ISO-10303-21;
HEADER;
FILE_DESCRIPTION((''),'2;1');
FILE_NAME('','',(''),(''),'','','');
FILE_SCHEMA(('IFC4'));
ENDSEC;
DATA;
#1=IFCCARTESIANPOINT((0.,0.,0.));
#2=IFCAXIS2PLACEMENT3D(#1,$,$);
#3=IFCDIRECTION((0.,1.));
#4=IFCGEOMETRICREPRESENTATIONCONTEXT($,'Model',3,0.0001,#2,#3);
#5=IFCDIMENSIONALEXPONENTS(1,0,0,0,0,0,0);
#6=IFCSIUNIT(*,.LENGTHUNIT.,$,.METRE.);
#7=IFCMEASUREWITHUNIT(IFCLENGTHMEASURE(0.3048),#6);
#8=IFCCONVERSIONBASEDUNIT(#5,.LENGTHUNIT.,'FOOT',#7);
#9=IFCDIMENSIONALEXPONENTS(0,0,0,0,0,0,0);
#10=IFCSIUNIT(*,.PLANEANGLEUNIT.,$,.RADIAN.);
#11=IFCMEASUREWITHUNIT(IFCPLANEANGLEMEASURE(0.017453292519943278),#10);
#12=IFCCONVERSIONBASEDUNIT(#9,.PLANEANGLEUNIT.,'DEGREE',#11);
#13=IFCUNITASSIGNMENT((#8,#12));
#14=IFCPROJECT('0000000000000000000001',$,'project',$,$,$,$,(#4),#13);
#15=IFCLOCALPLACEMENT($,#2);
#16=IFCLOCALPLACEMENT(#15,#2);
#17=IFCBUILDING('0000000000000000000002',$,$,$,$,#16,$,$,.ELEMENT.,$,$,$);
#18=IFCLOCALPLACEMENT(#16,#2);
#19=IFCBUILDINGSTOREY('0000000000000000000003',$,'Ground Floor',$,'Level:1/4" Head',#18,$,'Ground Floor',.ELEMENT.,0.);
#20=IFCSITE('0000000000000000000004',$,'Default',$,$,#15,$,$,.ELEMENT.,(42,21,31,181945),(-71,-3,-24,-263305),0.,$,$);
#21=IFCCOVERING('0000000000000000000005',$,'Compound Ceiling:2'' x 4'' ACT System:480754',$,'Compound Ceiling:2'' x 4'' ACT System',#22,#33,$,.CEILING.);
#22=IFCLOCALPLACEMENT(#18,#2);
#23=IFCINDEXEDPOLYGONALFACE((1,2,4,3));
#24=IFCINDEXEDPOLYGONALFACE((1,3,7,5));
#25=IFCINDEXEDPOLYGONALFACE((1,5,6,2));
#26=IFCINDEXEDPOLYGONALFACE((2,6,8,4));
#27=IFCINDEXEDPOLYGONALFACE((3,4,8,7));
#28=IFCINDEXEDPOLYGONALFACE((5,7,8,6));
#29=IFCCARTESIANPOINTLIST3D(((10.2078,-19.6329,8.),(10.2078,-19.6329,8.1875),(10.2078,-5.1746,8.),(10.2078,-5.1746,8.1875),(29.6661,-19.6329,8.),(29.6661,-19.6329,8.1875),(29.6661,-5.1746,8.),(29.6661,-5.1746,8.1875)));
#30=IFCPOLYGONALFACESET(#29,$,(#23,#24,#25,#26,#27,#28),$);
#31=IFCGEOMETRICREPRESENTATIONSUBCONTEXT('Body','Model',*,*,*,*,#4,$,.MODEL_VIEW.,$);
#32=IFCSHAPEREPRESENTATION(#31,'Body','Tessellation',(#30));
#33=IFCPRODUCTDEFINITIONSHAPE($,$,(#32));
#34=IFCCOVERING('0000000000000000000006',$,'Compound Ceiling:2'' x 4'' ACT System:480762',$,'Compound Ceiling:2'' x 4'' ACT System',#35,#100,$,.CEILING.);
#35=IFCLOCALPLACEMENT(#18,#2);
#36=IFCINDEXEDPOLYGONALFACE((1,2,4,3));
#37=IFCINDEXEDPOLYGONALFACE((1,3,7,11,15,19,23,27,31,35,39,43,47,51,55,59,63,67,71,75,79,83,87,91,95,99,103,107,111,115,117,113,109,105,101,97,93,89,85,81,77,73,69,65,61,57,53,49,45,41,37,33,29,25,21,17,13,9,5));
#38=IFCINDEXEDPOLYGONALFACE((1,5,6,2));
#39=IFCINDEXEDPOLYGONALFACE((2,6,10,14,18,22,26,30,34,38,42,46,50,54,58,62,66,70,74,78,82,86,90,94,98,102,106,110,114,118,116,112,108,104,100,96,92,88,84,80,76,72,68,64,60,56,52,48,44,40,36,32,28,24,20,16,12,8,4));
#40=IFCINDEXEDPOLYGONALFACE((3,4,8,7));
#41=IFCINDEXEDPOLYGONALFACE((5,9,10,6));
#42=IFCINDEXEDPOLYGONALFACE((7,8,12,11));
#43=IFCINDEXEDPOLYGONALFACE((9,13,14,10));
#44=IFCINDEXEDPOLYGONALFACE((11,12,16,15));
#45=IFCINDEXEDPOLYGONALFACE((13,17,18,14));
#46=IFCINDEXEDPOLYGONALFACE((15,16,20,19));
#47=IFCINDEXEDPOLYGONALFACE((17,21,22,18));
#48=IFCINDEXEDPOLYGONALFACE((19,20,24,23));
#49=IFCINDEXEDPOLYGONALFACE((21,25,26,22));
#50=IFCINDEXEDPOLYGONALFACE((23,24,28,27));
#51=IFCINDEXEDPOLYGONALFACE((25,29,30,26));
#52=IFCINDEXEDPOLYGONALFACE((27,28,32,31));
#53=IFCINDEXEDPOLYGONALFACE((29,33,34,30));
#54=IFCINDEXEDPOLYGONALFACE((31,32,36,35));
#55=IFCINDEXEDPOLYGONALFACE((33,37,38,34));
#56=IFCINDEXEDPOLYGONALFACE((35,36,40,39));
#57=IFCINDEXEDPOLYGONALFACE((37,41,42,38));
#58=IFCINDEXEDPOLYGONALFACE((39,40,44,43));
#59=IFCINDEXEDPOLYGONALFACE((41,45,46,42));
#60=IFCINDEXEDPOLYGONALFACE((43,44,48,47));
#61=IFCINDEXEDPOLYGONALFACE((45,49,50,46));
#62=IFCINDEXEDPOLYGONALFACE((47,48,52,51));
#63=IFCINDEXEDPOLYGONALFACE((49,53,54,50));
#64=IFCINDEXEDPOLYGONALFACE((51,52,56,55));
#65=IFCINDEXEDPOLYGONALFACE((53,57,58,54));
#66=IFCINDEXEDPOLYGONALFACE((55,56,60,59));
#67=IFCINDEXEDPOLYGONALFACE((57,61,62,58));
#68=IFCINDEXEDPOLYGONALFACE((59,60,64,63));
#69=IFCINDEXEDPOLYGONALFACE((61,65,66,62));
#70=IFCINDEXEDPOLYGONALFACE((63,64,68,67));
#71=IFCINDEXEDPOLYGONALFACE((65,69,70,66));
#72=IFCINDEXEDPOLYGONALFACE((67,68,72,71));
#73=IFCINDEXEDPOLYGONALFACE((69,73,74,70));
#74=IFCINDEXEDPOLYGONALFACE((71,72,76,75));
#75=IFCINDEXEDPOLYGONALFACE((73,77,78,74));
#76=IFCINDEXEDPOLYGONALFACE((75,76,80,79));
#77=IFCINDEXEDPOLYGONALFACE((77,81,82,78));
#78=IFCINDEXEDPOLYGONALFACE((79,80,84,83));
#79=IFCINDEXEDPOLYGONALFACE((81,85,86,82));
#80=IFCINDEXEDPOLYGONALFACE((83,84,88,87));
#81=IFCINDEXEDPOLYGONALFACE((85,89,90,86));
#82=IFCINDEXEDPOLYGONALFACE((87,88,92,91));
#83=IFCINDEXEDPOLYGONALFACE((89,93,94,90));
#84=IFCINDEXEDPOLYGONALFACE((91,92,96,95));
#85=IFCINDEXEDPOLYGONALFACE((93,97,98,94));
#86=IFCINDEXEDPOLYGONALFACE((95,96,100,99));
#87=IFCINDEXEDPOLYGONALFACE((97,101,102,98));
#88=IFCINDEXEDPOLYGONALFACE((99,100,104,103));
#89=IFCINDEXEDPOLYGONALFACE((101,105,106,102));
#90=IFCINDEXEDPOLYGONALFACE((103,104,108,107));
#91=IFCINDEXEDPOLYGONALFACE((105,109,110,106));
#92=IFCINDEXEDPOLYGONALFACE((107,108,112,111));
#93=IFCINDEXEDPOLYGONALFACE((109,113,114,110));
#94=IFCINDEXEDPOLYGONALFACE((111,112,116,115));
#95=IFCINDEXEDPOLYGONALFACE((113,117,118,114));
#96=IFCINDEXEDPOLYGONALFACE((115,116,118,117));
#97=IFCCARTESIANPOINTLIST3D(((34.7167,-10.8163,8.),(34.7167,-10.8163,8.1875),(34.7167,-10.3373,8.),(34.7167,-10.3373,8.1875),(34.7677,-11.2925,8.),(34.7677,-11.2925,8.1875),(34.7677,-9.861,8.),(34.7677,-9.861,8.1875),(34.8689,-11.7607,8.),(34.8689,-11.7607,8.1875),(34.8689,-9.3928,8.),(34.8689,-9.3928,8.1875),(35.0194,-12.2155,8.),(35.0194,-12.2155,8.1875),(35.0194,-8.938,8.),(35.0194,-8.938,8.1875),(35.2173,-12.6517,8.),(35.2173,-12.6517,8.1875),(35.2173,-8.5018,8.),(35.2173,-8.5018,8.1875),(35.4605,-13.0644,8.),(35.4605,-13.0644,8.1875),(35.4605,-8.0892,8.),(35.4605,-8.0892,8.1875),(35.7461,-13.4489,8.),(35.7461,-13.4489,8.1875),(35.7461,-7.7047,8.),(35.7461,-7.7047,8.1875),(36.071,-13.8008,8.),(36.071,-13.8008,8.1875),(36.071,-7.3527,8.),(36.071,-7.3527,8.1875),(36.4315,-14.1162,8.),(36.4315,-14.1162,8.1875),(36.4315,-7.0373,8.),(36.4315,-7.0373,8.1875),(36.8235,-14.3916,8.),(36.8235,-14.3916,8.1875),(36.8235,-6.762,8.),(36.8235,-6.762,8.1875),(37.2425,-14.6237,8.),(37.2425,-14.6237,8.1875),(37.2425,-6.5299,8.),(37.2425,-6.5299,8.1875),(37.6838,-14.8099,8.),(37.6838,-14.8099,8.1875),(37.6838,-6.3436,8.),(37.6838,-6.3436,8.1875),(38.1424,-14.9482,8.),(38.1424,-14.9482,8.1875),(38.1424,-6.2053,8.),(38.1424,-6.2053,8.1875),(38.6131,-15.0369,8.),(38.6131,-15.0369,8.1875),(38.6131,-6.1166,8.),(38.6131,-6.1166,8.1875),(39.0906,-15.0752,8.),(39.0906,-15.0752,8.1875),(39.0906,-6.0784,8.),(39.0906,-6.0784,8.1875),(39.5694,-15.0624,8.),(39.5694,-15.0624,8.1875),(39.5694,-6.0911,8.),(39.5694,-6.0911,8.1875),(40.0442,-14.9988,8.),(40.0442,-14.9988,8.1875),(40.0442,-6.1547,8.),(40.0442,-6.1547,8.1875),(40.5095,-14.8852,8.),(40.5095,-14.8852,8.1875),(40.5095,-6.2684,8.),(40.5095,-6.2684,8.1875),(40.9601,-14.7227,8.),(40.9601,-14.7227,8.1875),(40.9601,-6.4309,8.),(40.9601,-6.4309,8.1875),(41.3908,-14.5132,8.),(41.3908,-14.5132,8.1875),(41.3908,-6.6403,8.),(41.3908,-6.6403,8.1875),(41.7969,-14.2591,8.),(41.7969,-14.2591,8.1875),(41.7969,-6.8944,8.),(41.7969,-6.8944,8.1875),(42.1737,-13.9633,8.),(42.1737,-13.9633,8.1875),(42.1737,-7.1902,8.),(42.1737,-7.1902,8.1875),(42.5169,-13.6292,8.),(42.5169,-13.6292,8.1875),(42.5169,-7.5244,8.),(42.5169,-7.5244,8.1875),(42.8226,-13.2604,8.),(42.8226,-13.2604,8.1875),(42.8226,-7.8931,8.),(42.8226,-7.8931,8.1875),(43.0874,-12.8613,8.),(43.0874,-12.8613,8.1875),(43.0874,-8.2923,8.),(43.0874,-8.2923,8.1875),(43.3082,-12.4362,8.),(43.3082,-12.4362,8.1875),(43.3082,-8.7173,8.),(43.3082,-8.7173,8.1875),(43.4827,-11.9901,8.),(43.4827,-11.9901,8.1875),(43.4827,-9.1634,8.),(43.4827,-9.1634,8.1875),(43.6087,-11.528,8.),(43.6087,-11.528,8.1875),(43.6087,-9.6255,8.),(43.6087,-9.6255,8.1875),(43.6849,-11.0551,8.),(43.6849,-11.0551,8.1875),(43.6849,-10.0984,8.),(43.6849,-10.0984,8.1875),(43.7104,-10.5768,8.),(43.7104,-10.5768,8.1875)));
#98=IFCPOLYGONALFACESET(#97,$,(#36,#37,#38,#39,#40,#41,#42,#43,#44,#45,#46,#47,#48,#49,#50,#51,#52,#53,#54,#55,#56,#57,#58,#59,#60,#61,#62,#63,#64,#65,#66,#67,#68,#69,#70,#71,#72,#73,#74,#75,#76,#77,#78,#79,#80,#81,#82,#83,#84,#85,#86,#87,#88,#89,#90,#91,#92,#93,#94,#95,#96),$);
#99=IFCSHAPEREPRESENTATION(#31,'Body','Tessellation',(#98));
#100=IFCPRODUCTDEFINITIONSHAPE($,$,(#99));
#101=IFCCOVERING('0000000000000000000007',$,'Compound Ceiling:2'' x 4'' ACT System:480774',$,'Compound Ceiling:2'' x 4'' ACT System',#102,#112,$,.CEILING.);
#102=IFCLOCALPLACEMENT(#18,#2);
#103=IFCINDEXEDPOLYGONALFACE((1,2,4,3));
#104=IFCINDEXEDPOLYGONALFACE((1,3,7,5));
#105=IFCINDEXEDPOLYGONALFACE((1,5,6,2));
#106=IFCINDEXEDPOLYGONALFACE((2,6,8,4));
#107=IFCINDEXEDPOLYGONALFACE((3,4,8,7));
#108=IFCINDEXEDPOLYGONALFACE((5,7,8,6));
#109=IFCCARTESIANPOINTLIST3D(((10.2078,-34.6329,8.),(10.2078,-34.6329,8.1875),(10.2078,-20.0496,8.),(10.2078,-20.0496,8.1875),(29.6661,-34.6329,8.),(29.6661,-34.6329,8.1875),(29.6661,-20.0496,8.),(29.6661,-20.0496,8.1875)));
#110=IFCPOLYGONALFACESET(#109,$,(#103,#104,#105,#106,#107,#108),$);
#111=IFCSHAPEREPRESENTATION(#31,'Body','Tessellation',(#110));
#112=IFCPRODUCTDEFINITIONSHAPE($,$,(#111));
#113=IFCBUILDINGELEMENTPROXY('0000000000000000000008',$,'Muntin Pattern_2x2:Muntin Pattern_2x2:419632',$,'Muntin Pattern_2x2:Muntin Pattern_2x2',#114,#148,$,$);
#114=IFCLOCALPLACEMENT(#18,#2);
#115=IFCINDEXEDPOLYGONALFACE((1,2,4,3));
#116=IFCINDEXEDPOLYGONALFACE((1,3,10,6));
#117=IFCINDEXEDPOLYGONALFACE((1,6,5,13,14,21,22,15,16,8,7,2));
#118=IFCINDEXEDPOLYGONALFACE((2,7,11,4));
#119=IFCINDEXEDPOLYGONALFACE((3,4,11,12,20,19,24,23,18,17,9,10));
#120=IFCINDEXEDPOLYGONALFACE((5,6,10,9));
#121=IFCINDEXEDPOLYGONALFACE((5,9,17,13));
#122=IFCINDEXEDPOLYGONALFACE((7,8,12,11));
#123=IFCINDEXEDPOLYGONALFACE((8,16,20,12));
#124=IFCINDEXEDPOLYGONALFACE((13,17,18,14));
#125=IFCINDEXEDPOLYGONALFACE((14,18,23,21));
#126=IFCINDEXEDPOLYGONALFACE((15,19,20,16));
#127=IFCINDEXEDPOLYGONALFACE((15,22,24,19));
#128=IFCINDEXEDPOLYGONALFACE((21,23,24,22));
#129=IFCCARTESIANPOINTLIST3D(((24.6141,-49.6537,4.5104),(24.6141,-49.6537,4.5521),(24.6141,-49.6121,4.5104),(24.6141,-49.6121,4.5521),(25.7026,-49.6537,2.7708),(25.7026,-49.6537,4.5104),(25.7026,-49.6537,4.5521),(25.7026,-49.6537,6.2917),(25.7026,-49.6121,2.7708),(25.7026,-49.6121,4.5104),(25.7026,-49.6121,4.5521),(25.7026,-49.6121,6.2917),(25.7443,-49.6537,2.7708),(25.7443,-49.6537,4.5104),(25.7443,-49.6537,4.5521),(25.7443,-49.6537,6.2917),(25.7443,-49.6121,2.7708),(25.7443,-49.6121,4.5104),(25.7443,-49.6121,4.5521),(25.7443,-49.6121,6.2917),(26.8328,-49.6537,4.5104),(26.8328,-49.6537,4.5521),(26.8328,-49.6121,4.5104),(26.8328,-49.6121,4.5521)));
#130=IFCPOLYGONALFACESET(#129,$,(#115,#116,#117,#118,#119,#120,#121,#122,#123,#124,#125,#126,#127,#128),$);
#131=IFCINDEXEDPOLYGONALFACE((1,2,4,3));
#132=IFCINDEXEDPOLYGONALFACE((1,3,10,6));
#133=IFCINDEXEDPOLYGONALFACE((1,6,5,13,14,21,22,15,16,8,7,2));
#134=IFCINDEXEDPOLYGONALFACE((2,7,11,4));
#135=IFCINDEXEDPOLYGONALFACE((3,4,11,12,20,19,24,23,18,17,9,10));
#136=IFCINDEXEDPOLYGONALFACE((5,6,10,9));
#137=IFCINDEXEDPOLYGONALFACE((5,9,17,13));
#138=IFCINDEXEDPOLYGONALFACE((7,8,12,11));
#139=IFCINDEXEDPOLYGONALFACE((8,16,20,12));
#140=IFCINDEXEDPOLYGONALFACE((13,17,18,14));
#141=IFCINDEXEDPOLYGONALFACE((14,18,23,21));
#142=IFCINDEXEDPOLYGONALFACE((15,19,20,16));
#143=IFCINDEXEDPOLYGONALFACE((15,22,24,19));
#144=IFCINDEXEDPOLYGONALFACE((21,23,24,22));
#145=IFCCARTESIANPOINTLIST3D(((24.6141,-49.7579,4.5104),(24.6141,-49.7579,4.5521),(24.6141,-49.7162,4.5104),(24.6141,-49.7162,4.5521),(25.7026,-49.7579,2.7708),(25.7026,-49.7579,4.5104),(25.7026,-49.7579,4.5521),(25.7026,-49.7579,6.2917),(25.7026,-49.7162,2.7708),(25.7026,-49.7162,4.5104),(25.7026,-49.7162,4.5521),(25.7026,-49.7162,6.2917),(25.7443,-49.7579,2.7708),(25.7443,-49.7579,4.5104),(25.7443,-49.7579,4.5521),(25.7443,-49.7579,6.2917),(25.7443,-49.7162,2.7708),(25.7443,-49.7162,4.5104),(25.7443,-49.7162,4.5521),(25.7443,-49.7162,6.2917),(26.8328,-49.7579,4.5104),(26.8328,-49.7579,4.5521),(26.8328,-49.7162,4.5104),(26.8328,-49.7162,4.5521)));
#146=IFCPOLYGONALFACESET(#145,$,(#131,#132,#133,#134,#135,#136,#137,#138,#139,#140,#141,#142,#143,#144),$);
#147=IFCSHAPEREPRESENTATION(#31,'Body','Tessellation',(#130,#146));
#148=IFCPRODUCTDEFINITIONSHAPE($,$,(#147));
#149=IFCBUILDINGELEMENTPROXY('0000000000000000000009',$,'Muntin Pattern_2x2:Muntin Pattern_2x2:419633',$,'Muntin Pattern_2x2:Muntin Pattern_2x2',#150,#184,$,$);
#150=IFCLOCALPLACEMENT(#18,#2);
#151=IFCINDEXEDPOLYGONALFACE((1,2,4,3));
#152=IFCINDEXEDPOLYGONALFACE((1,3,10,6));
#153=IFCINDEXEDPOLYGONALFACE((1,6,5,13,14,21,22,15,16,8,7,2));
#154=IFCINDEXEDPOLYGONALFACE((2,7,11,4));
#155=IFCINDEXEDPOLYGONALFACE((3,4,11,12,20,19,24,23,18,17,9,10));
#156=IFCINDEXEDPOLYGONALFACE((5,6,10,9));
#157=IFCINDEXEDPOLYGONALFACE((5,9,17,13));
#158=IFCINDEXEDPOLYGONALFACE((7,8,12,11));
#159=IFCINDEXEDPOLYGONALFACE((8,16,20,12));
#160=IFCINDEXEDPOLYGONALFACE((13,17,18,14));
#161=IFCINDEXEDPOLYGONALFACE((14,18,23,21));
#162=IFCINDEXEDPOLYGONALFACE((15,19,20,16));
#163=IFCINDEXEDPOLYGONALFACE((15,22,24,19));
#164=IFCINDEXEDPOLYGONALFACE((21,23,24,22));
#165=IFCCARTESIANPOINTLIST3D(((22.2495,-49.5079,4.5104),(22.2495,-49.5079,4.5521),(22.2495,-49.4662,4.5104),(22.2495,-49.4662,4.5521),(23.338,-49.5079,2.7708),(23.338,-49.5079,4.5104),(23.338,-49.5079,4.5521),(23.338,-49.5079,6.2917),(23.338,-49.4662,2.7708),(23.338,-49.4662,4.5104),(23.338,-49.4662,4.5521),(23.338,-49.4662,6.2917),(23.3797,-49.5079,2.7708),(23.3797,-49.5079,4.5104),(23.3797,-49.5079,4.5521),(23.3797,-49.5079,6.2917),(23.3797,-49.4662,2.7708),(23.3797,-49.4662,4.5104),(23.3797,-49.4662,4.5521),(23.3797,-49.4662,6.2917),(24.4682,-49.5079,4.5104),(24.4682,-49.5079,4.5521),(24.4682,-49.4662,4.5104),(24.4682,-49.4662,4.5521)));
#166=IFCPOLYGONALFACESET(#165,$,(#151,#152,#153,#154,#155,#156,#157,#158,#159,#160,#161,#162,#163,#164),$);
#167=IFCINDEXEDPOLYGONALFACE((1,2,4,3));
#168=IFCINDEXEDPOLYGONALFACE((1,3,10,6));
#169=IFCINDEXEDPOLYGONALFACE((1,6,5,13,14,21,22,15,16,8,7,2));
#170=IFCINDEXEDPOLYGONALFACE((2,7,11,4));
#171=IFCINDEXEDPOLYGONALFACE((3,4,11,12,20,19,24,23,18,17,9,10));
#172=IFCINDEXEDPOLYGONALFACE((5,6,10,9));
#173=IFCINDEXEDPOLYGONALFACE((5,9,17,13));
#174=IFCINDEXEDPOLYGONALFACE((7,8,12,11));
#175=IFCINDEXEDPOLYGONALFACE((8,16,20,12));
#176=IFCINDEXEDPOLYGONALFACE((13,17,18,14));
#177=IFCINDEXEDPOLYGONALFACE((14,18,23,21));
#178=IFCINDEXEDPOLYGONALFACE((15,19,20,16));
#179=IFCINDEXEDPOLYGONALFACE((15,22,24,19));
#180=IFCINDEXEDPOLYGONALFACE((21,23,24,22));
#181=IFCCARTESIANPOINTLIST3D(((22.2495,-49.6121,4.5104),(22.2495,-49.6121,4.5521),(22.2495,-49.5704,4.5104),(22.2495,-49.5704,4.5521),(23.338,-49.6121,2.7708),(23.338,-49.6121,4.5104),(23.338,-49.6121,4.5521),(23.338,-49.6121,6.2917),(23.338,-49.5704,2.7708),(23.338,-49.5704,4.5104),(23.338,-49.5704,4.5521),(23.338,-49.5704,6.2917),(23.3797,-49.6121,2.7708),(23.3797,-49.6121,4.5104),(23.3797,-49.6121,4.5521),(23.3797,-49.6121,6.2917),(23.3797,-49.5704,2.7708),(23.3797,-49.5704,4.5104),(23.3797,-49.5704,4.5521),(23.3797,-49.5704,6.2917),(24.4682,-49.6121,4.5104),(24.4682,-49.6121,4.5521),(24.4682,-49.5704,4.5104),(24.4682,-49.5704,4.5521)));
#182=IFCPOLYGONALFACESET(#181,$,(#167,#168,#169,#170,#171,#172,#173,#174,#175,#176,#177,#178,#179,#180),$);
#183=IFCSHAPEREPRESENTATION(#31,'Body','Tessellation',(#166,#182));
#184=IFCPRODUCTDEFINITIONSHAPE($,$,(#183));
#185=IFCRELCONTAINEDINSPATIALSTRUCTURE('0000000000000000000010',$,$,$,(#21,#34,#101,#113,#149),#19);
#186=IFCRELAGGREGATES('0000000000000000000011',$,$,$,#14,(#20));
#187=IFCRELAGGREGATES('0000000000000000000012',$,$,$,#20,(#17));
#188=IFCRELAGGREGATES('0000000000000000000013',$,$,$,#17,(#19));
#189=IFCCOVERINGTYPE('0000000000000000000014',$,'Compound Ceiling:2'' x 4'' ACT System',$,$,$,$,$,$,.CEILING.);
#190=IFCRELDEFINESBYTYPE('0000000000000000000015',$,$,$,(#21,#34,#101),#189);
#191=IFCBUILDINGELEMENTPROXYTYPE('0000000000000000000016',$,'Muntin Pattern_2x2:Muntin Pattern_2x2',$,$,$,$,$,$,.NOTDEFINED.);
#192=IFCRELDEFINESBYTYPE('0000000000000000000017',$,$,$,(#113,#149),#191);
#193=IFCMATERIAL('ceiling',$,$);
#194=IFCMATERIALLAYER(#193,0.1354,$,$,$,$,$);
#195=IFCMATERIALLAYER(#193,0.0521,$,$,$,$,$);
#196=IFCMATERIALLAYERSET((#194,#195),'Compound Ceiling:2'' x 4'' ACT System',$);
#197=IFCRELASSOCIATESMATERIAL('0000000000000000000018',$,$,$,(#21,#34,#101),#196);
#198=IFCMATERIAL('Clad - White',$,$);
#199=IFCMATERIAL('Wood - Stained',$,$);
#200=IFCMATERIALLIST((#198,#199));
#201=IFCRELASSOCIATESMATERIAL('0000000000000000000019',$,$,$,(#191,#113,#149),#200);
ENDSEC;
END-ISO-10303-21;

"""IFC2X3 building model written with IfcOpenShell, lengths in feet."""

from ifc_helpers import new_model, entity, si_unit, converted_unit, direction, frame, frame_2d, origin, place, context, subcontext, project, spatial, polyline, rectangle, circle, outline, extrude, source, transform, mapped, material, material_list, layer, layer_set, layer_usage, type_object, type_shapes, element, save


model = new_model("IFC2X3")

# Units and contexts
model_context = context("Model", 3, precision=0.0001, world=origin(), true_north=direction((0.0, 1.0)))
body_context = subcontext(model_context, "Body", "Model", "MODEL_VIEW")
ifc_project = project(units=[converted_unit("LENGTHUNIT", "FOOT", entity("IfcLengthMeasure", 0.3048), si_unit("LENGTHUNIT", "METRE"), dimensions=[1, 0, 0, 0, 0, 0, 0]), converted_unit("PLANEANGLEUNIT", "DEGREE", entity("IfcPlaneAngleMeasure", 0.017453292519943278), si_unit("PLANEANGLEUNIT", "RADIAN"), dimensions=[0, 0, 0, 0, 0, 0, 0])], contexts=[model_context])

# Site, building, storey
site_placement = place(None, origin())
site = spatial("IfcSite", under=ifc_project, at=site_placement, Name="Default", CompositionType="ELEMENT", RefLatitude=(42, 21, 31, 181945), RefLongitude=(-71, -3, -24, -263305), RefElevation=0.0)
building_placement = place(site_placement, origin())
building = spatial("IfcBuilding", under=site, at=building_placement, CompositionType="ELEMENT")
storey_placement = place(building_placement, origin())
storey = spatial("IfcBuildingStorey", under=building, at=storey_placement, Name="Ground Floor", ObjectType="Level:1/4\" Head", LongName="Ground Floor", CompositionType="ELEMENT", Elevation=0.0)

# Coverings
ifc_material_1 = material(Name="ceiling")
ifc_layer_1 = layer(ifc_material_1, 0.1354)
ifc_layer_2 = layer(ifc_material_1, 0.0521)
ifc_layer_set_1 = layer_set([ifc_layer_1, ifc_layer_2], Name="Compound Ceiling:2' x 4' ACT System")
ifc_layer_usage_1 = layer_usage(ifc_layer_set_1, "AXIS3", "NEGATIVE", 0.1875)
covering_type = type_object("IfcCoveringType", Name="Compound Ceiling:2' x 4' ACT System", PredefinedType="CEILING")
covering_1_placement = place(storey_placement, origin())
element("IfcCovering", 1, at=covering_1_placement, inside=storey, type_object=covering_type, material=ifc_layer_usage_1, Name="Compound Ceiling:2' x 4' ACT System:480754", ObjectType="Compound Ceiling:2' x 4' ACT System", PredefinedType="CEILING", context=body_context, shape_type="SweptSolid", body=[
    extrude(rectangle(XDim=14.4583, YDim=19.4583, at=frame_2d((0.0, 0.0), x_axis=(1.0, 0.0))), frame((19.937, -12.4037, 8.0), z_axis=(0.0, 0.0, 1.0), x_axis=(0.0, -1.0, 0.0)), (0.0, 0.0, 1.0), 0.1875),
])
covering_2_placement = place(storey_placement, origin())
element("IfcCovering", 2, at=covering_2_placement, inside=storey, type_object=covering_type, material=ifc_layer_usage_1, Name="Compound Ceiling:2' x 4' ACT System:480762", ObjectType="Compound Ceiling:2' x 4' ACT System", PredefinedType="CEILING", context=body_context, shape_type="SweptSolid", body=[
    extrude(circle(Radius=4.5, at=frame_2d((0.0, 0.0), x_axis=(1.0, 0.0))), frame((39.2104, -10.5768, 8.0)), (0.0, 0.0, 1.0), 0.1875),
])
covering_3_placement = place(storey_placement, origin())
element("IfcCovering", 3, at=covering_3_placement, inside=storey, type_object=covering_type, material=ifc_layer_usage_1, Name="Compound Ceiling:2' x 4' ACT System:480774", ObjectType="Compound Ceiling:2' x 4' ACT System", PredefinedType="CEILING", context=body_context, shape_type="SweptSolid", body=[
    extrude(rectangle(XDim=19.4583, YDim=14.5833, at=frame_2d((0.0, 0.0), x_axis=(1.0, 0.0))), frame((19.937, -27.3412, 8.0)), (0.0, 0.0, 1.0), 0.1875),
])

# Building element proxies
ifc_material_2 = material(Name="Clad - White")
ifc_material_3 = material(Name="Wood - Stained")
ifc_material_list_1 = material_list([ifc_material_2, ifc_material_3])
building_element_proxy_type_1 = type_object("IfcBuildingElementProxyType", Name="Muntin Pattern_2x2:Muntin Pattern_2x2", PredefinedType="NOTDEFINED", material=ifc_material_list_1)
shared_shape_1 = source(origin(), body_context, "Body", "SweptSolid", [
    extrude(outline(polyline([(0.0208, -0.0208), (1.7604, -0.0208), (1.7604, 0.0208), (0.0208, 0.0208), (0.0208, 1.1094), (-0.0208, 1.1094), (-0.0208, 0.0208), (-1.7604, 0.0208), (-1.7604, -0.0208), (-0.0208, -0.0208), (-0.0208, -1.1094), (0.0208, -1.1094), (0.0208, -0.0208)])), frame((0.0, 0.0313, 1.7604), z_axis=(0.0, 1.0, 0.0), x_axis=(0.0, 0.0, 1.0)), (0.0, 0.0, 1.0), 0.0417),
    extrude(outline(polyline([(0.0208, -0.0208), (1.7604, -0.0208), (1.7604, 0.0208), (0.0208, 0.0208), (0.0208, 1.1094), (-0.0208, 1.1094), (-0.0208, 0.0208), (-1.7604, 0.0208), (-1.7604, -0.0208), (-0.0208, -0.0208), (-0.0208, -1.1094), (0.0208, -1.1094), (0.0208, -0.0208)])), frame((0.0, -0.0729, 1.7604), z_axis=(0.0, 1.0, 0.0), x_axis=(0.0, 0.0, 1.0)), (0.0, 0.0, 1.0), 0.0417),
])
type_shapes(building_element_proxy_type_1, [shared_shape_1])
for number, where, name in (
    (4, (25.7234, -49.685, 2.7708), "Muntin Pattern_2x2:Muntin Pattern_2x2:419632"),
    (5, (23.3589, -49.5392, 2.7708), "Muntin Pattern_2x2:Muntin Pattern_2x2:419633"),
):
    element("IfcBuildingElementProxy", number, at=place(storey_placement, frame(where)), inside=storey, type_object=building_element_proxy_type_1, material=ifc_material_list_1, Name=name, ObjectType="Muntin Pattern_2x2:Muntin Pattern_2x2", context=body_context, shape_type="MappedRepresentation", body=[
        mapped(shared_shape_1, transform((0.0, 0.0, 0.0), scale=1.0)),
    ])

save(model, "model.ifc")
